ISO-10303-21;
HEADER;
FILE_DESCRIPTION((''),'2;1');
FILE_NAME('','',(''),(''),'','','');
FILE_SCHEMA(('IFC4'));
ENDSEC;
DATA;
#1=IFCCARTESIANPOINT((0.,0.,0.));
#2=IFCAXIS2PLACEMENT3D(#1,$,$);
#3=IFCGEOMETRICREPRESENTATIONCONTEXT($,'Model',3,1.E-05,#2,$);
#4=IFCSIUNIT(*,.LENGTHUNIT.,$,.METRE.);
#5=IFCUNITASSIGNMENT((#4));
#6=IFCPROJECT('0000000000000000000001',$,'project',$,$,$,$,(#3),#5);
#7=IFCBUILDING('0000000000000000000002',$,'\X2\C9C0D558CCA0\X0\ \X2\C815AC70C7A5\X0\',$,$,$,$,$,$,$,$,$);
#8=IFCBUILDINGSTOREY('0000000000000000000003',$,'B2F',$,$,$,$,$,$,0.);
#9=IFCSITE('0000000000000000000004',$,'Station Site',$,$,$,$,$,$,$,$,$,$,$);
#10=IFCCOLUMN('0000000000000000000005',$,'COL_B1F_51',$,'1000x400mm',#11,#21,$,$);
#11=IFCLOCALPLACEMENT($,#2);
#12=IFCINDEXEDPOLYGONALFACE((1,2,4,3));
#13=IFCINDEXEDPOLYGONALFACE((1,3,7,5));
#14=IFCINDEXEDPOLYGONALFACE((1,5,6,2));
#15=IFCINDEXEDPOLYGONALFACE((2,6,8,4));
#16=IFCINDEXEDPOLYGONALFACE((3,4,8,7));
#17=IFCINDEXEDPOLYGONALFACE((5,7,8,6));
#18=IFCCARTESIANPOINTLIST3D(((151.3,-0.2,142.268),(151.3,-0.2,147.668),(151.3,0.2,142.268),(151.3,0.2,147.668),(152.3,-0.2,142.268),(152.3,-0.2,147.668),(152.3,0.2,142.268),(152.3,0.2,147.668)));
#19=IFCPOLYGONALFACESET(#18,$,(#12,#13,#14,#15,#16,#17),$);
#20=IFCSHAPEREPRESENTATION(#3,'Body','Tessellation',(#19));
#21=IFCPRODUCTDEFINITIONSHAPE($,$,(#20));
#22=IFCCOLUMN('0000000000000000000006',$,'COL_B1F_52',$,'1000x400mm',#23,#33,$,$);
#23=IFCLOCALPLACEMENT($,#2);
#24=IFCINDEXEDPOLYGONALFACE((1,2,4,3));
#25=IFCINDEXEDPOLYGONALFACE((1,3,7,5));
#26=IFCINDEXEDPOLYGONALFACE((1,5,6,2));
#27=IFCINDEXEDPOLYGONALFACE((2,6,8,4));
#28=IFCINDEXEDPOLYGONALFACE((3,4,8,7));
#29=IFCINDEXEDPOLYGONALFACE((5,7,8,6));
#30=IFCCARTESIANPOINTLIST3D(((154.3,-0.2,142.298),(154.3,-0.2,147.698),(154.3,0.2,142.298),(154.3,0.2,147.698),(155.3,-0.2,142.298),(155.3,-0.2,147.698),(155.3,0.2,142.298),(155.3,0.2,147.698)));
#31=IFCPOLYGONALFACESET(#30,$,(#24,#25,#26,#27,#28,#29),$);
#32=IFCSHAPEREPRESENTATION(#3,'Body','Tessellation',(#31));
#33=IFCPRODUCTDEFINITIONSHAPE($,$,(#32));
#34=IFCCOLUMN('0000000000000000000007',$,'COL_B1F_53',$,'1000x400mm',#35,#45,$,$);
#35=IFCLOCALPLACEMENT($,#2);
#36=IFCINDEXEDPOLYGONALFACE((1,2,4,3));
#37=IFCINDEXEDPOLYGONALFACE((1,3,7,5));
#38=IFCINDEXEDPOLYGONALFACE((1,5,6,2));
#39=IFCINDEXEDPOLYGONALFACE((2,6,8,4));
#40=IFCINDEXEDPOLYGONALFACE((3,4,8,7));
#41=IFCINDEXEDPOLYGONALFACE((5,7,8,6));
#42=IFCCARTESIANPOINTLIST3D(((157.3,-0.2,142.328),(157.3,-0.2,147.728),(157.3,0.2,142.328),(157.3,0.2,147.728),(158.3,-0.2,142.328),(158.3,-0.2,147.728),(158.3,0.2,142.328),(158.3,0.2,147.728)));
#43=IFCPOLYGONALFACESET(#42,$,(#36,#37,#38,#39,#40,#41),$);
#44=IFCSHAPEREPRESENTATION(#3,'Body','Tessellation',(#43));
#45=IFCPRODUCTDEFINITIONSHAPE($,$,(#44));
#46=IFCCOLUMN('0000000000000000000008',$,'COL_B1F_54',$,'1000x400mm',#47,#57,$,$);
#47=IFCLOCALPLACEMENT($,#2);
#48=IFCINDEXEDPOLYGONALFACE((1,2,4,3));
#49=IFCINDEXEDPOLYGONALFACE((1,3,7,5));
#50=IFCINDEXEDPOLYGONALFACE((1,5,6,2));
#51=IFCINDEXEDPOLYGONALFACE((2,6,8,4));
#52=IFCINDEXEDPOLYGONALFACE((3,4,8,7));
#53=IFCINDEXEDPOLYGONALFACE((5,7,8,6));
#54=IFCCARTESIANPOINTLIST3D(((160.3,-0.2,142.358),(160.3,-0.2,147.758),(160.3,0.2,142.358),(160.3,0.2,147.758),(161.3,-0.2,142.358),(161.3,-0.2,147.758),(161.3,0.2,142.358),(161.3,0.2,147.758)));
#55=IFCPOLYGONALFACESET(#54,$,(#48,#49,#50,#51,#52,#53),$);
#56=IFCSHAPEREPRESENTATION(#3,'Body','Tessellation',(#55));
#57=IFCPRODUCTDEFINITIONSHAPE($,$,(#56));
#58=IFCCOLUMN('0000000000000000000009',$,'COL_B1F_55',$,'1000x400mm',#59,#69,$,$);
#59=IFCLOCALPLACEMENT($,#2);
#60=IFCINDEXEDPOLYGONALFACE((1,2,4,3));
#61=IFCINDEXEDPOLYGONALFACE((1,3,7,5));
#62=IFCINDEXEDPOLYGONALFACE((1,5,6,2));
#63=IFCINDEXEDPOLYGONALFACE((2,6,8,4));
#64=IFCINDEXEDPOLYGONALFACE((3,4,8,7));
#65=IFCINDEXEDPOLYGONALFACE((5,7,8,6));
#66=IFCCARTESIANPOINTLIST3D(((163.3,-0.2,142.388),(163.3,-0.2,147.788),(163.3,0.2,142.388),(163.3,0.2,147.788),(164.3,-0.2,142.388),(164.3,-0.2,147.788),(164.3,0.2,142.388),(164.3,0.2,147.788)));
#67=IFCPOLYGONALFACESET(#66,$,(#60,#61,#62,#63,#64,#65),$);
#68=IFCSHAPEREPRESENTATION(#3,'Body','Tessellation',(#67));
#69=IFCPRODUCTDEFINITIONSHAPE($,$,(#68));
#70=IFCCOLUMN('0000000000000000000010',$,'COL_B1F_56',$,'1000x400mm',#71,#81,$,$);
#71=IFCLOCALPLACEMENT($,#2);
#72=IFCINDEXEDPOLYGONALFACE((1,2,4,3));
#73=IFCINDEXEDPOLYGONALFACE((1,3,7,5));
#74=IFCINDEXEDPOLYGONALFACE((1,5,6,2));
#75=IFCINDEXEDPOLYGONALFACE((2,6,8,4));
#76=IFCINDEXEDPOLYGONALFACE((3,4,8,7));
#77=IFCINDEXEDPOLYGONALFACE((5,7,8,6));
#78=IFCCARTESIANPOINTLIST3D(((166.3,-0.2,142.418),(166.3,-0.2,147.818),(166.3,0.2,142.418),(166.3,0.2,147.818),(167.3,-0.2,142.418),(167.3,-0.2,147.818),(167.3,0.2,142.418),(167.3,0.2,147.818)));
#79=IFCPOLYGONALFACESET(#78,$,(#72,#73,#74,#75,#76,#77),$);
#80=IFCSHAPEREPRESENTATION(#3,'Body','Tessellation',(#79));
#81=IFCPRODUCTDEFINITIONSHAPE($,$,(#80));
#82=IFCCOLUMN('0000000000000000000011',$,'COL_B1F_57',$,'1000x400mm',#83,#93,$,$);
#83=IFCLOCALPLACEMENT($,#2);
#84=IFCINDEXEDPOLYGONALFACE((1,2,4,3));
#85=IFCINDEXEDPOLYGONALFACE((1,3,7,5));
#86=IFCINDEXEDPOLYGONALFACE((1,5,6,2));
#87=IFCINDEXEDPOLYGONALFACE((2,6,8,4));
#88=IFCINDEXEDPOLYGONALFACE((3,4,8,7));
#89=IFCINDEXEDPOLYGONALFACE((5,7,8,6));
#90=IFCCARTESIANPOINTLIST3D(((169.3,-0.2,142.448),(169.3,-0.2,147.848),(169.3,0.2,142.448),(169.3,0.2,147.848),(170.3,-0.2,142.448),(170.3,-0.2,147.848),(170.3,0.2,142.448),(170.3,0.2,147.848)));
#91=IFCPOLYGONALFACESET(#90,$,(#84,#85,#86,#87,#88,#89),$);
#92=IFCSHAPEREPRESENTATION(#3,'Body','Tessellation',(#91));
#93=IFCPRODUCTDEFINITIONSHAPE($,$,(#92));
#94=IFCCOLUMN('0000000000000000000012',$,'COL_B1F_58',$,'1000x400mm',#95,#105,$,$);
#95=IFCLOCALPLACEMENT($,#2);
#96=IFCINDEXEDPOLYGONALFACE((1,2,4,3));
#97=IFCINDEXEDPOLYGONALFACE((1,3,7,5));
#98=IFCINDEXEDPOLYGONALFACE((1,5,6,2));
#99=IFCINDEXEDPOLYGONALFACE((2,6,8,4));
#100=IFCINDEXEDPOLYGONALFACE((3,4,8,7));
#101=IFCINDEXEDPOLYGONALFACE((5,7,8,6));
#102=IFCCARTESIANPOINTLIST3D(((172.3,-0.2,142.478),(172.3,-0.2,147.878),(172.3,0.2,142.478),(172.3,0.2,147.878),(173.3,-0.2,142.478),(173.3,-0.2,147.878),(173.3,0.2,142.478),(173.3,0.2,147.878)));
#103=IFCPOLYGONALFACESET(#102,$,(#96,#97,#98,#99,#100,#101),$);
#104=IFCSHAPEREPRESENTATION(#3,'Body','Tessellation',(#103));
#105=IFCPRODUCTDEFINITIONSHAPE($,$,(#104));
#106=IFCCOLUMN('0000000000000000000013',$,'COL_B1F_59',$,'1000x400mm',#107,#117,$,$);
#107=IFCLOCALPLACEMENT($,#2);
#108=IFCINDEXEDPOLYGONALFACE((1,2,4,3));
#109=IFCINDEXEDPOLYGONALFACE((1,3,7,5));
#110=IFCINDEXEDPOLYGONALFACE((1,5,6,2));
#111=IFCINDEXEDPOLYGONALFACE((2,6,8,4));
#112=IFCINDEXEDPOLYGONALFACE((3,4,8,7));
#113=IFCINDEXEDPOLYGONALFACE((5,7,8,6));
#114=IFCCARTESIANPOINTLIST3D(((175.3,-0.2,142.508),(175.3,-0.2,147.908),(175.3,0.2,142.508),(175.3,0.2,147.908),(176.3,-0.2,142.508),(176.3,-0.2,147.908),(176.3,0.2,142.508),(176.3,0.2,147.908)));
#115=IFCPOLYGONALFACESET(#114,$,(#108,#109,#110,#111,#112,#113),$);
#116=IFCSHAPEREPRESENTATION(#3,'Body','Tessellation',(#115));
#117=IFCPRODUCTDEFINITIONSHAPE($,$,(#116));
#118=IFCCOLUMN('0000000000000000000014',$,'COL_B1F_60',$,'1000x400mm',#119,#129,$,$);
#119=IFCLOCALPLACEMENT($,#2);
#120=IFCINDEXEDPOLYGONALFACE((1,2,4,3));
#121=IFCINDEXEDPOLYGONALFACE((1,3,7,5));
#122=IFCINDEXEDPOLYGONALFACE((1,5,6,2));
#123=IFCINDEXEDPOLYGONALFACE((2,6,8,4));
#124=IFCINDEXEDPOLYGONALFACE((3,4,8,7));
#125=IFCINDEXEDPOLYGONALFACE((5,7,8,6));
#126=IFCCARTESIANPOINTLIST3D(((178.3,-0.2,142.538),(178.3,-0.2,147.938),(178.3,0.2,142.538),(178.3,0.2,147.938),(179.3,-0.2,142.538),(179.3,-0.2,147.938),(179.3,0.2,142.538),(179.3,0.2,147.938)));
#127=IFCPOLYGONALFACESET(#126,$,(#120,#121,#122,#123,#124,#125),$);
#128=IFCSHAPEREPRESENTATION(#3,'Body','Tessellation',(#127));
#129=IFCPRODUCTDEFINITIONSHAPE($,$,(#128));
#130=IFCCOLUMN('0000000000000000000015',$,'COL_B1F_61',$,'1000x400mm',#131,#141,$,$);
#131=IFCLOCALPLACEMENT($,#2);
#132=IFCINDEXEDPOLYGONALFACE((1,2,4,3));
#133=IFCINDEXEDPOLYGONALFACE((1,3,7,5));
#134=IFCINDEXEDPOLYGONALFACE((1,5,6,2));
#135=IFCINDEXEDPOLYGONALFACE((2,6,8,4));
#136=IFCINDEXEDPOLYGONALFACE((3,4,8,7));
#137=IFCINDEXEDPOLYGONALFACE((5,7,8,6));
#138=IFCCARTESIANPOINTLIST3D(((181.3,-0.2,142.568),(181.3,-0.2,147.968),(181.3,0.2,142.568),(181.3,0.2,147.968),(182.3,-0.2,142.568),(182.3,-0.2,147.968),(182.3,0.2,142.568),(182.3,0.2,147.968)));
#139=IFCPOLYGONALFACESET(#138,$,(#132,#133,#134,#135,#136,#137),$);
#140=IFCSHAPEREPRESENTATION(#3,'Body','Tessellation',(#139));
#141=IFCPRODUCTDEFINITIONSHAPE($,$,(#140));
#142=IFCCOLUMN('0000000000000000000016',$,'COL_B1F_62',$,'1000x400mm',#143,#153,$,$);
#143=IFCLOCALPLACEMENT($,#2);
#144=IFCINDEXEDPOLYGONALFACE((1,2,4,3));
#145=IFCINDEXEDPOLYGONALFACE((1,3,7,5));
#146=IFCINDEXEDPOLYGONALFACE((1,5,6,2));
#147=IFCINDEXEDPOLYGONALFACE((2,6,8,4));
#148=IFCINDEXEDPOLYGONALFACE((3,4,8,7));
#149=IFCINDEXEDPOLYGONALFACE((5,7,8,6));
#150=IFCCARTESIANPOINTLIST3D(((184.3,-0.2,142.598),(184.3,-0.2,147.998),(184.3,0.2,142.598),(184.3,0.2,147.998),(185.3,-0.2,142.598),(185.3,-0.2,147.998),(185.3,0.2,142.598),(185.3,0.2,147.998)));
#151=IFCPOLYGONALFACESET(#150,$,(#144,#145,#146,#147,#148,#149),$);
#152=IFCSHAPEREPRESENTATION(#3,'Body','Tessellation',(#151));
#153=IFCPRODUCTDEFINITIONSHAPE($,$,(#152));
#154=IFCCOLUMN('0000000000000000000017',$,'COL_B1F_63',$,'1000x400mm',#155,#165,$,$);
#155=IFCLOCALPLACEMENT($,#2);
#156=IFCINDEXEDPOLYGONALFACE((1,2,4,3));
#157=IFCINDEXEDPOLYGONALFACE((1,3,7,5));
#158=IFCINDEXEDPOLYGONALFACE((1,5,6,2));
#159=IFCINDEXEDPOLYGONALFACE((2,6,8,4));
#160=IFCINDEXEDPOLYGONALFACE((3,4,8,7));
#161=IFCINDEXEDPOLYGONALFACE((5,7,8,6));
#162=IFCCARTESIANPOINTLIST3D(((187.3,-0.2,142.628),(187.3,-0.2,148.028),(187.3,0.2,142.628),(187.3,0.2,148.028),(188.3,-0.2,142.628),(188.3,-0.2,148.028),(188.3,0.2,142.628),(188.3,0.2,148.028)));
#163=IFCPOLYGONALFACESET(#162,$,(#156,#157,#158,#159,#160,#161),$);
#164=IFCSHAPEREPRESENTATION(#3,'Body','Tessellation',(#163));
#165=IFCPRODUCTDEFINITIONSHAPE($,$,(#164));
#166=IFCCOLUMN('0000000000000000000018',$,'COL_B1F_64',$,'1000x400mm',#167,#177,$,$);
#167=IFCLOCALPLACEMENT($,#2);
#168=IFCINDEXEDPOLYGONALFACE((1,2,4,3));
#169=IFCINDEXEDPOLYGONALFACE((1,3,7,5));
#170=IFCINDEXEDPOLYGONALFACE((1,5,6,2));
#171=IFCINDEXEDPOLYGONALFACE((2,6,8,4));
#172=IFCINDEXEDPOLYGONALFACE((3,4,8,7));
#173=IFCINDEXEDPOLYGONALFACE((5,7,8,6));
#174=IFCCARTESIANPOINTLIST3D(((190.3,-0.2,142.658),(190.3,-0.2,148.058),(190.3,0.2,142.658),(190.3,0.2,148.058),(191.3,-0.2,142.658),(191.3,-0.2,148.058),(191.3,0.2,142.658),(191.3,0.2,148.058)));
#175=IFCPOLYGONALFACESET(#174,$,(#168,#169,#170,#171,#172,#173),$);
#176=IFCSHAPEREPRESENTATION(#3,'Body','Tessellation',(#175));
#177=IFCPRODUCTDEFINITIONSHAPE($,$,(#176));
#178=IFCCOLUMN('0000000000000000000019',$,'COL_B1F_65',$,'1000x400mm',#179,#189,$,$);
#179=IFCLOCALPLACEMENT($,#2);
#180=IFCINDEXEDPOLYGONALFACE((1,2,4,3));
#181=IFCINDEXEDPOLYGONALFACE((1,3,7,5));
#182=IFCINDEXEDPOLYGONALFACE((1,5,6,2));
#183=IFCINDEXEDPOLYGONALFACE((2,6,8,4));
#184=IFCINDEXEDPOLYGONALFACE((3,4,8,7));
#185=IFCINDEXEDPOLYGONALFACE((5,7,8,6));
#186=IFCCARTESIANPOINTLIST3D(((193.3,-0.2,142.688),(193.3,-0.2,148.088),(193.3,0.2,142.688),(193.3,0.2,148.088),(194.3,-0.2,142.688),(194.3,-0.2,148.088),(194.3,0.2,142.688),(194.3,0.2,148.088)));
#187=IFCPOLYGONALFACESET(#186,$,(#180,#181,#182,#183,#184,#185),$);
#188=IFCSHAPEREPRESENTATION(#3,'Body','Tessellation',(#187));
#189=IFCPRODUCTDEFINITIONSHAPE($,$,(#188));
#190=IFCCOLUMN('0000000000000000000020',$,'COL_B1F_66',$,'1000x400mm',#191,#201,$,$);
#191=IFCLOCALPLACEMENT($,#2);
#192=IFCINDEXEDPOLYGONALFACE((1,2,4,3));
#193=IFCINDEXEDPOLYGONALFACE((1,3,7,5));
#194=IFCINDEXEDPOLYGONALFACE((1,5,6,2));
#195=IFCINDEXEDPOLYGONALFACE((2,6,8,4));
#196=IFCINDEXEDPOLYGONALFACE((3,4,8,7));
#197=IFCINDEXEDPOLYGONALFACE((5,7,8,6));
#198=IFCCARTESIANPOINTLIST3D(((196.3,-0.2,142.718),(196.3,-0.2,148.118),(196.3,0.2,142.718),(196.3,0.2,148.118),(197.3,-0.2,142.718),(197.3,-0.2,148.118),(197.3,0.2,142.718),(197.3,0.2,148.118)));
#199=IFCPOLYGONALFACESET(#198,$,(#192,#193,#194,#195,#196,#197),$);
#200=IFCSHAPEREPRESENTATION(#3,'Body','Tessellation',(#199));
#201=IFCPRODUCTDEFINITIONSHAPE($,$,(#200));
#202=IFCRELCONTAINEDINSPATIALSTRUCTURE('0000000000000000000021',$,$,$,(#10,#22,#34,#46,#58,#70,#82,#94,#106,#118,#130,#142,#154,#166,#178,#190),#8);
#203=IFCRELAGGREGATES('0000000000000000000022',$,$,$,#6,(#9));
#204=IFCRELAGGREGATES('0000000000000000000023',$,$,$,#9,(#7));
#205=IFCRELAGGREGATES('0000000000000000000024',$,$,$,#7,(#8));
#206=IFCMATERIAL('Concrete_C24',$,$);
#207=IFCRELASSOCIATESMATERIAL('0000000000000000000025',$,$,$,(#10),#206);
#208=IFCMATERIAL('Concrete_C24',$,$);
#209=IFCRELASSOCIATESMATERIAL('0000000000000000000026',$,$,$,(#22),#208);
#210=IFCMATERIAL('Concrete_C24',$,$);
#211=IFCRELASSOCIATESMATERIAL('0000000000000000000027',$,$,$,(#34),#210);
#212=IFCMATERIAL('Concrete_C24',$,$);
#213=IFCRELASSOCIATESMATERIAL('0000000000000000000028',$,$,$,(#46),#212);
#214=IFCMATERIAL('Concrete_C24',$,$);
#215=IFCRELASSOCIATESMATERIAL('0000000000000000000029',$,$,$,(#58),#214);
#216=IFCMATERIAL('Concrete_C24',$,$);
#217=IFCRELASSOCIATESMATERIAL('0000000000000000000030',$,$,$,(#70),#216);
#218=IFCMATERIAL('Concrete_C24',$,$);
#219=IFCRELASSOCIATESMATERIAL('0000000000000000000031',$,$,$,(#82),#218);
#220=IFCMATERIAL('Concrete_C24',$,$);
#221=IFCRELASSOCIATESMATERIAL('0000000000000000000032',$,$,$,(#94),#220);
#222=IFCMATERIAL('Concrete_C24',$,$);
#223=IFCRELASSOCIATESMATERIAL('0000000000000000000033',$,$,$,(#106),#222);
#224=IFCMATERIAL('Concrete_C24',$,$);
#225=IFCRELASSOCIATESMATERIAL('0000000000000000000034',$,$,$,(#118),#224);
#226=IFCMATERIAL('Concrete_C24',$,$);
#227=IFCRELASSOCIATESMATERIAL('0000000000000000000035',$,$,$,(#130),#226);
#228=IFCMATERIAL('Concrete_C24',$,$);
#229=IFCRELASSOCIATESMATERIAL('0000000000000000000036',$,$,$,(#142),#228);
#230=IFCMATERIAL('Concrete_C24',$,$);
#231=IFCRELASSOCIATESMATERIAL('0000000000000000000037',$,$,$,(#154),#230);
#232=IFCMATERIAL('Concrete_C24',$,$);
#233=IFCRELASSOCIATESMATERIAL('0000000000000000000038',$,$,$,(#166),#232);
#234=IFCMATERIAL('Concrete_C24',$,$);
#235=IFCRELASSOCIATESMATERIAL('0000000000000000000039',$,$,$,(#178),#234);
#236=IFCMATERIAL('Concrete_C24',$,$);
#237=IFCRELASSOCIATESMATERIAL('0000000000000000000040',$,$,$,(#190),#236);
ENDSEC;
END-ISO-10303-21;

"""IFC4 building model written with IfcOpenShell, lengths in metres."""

from ifc_helpers import new_model, si_unit, frame, origin, place, context, project, spatial, rectangle, extrude, material, element, save


model = new_model("IFC4")

# Units and contexts
model_context = context("Model", 3, precision=1e-05, world=origin())
ifc_project = project(units=[si_unit("LENGTHUNIT", "METRE")], contexts=[model_context])

# Site, building, storey
site = spatial("IfcSite", under=ifc_project, Name="Station Site")
building = spatial("IfcBuilding", under=site, Name="지하철 정거장")
storey = spatial("IfcBuildingStorey", under=building, Name="B2F", Elevation=0.0)

# Columns
ifc_material_1 = material(Name="Concrete_C24")
column_1_placement = place(None, frame((151.8, 0.0, 142.268)))
element("IfcColumn", 1, at=column_1_placement, inside=storey, material=ifc_material_1, Name="COL_B1F_51", ObjectType="1000x400mm", context=model_context, shape_type="SweptSolid", body=[
    extrude(rectangle(XDim=1.0, YDim=0.4), origin(), (0.0, 0.0, 1.0), 5.4),
])
ifc_material_2 = material(Name="Concrete_C24")
column_2_placement = place(None, frame((154.8, 0.0, 142.298)))
element("IfcColumn", 2, at=column_2_placement, inside=storey, material=ifc_material_2, Name="COL_B1F_52", ObjectType="1000x400mm", context=model_context, shape_type="SweptSolid", body=[
    extrude(rectangle(XDim=1.0, YDim=0.4), origin(), (0.0, 0.0, 1.0), 5.4),
])
ifc_material_3 = material(Name="Concrete_C24")
column_3_placement = place(None, frame((157.8, 0.0, 142.328)))
element("IfcColumn", 3, at=column_3_placement, inside=storey, material=ifc_material_3, Name="COL_B1F_53", ObjectType="1000x400mm", context=model_context, shape_type="SweptSolid", body=[
    extrude(rectangle(XDim=1.0, YDim=0.4), origin(), (0.0, 0.0, 1.0), 5.4),
])
ifc_material_4 = material(Name="Concrete_C24")
column_4_placement = place(None, frame((160.8, 0.0, 142.358)))
element("IfcColumn", 4, at=column_4_placement, inside=storey, material=ifc_material_4, Name="COL_B1F_54", ObjectType="1000x400mm", context=model_context, shape_type="SweptSolid", body=[
    extrude(rectangle(XDim=1.0, YDim=0.4), origin(), (0.0, 0.0, 1.0), 5.4),
])
ifc_material_5 = material(Name="Concrete_C24")
column_5_placement = place(None, frame((163.8, 0.0, 142.388)))
element("IfcColumn", 5, at=column_5_placement, inside=storey, material=ifc_material_5, Name="COL_B1F_55", ObjectType="1000x400mm", context=model_context, shape_type="SweptSolid", body=[
    extrude(rectangle(XDim=1.0, YDim=0.4), origin(), (0.0, 0.0, 1.0), 5.4),
])
ifc_material_6 = material(Name="Concrete_C24")
column_6_placement = place(None, frame((166.8, 0.0, 142.418)))
element("IfcColumn", 6, at=column_6_placement, inside=storey, material=ifc_material_6, Name="COL_B1F_56", ObjectType="1000x400mm", context=model_context, shape_type="SweptSolid", body=[
    extrude(rectangle(XDim=1.0, YDim=0.4), origin(), (0.0, 0.0, 1.0), 5.4),
])
ifc_material_7 = material(Name="Concrete_C24")
column_7_placement = place(None, frame((169.8, 0.0, 142.448)))
element("IfcColumn", 7, at=column_7_placement, inside=storey, material=ifc_material_7, Name="COL_B1F_57", ObjectType="1000x400mm", context=model_context, shape_type="SweptSolid", body=[
    extrude(rectangle(XDim=1.0, YDim=0.4), origin(), (0.0, 0.0, 1.0), 5.4),
])
ifc_material_8 = material(Name="Concrete_C24")
column_8_placement = place(None, frame((172.8, 0.0, 142.478)))
element("IfcColumn", 8, at=column_8_placement, inside=storey, material=ifc_material_8, Name="COL_B1F_58", ObjectType="1000x400mm", context=model_context, shape_type="SweptSolid", body=[
    extrude(rectangle(XDim=1.0, YDim=0.4), origin(), (0.0, 0.0, 1.0), 5.4),
])
ifc_material_9 = material(Name="Concrete_C24")
column_9_placement = place(None, frame((175.8, 0.0, 142.508)))
element("IfcColumn", 9, at=column_9_placement, inside=storey, material=ifc_material_9, Name="COL_B1F_59", ObjectType="1000x400mm", context=model_context, shape_type="SweptSolid", body=[
    extrude(rectangle(XDim=1.0, YDim=0.4), origin(), (0.0, 0.0, 1.0), 5.4),
])
ifc_material_10 = material(Name="Concrete_C24")
column_10_placement = place(None, frame((178.8, 0.0, 142.538)))
element("IfcColumn", 10, at=column_10_placement, inside=storey, material=ifc_material_10, Name="COL_B1F_60", ObjectType="1000x400mm", context=model_context, shape_type="SweptSolid", body=[
    extrude(rectangle(XDim=1.0, YDim=0.4), origin(), (0.0, 0.0, 1.0), 5.4),
])
ifc_material_11 = material(Name="Concrete_C24")
column_11_placement = place(None, frame((181.8, 0.0, 142.568)))
element("IfcColumn", 11, at=column_11_placement, inside=storey, material=ifc_material_11, Name="COL_B1F_61", ObjectType="1000x400mm", context=model_context, shape_type="SweptSolid", body=[
    extrude(rectangle(XDim=1.0, YDim=0.4), origin(), (0.0, 0.0, 1.0), 5.4),
])
ifc_material_12 = material(Name="Concrete_C24")
column_12_placement = place(None, frame((184.8, 0.0, 142.598)))
element("IfcColumn", 12, at=column_12_placement, inside=storey, material=ifc_material_12, Name="COL_B1F_62", ObjectType="1000x400mm", context=model_context, shape_type="SweptSolid", body=[
    extrude(rectangle(XDim=1.0, YDim=0.4), origin(), (0.0, 0.0, 1.0), 5.4),
])
ifc_material_13 = material(Name="Concrete_C24")
column_13_placement = place(None, frame((187.8, 0.0, 142.628)))
element("IfcColumn", 13, at=column_13_placement, inside=storey, material=ifc_material_13, Name="COL_B1F_63", ObjectType="1000x400mm", context=model_context, shape_type="SweptSolid", body=[
    extrude(rectangle(XDim=1.0, YDim=0.4), origin(), (0.0, 0.0, 1.0), 5.4),
])
ifc_material_14 = material(Name="Concrete_C24")
column_14_placement = place(None, frame((190.8, 0.0, 142.658)))
element("IfcColumn", 14, at=column_14_placement, inside=storey, material=ifc_material_14, Name="COL_B1F_64", ObjectType="1000x400mm", context=model_context, shape_type="SweptSolid", body=[
    extrude(rectangle(XDim=1.0, YDim=0.4), origin(), (0.0, 0.0, 1.0), 5.4),
])
ifc_material_15 = material(Name="Concrete_C24")
column_15_placement = place(None, frame((193.8, 0.0, 142.688)))
element("IfcColumn", 15, at=column_15_placement, inside=storey, material=ifc_material_15, Name="COL_B1F_65", ObjectType="1000x400mm", context=model_context, shape_type="SweptSolid", body=[
    extrude(rectangle(XDim=1.0, YDim=0.4), origin(), (0.0, 0.0, 1.0), 5.4),
])
ifc_material_16 = material(Name="Concrete_C24")
column_16_placement = place(None, frame((196.8, 0.0, 142.718)))
element("IfcColumn", 16, at=column_16_placement, inside=storey, material=ifc_material_16, Name="COL_B1F_66", ObjectType="1000x400mm", context=model_context, shape_type="SweptSolid", body=[
    extrude(rectangle(XDim=1.0, YDim=0.4), origin(), (0.0, 0.0, 1.0), 5.4),
])

save(model, "model.ifc")
